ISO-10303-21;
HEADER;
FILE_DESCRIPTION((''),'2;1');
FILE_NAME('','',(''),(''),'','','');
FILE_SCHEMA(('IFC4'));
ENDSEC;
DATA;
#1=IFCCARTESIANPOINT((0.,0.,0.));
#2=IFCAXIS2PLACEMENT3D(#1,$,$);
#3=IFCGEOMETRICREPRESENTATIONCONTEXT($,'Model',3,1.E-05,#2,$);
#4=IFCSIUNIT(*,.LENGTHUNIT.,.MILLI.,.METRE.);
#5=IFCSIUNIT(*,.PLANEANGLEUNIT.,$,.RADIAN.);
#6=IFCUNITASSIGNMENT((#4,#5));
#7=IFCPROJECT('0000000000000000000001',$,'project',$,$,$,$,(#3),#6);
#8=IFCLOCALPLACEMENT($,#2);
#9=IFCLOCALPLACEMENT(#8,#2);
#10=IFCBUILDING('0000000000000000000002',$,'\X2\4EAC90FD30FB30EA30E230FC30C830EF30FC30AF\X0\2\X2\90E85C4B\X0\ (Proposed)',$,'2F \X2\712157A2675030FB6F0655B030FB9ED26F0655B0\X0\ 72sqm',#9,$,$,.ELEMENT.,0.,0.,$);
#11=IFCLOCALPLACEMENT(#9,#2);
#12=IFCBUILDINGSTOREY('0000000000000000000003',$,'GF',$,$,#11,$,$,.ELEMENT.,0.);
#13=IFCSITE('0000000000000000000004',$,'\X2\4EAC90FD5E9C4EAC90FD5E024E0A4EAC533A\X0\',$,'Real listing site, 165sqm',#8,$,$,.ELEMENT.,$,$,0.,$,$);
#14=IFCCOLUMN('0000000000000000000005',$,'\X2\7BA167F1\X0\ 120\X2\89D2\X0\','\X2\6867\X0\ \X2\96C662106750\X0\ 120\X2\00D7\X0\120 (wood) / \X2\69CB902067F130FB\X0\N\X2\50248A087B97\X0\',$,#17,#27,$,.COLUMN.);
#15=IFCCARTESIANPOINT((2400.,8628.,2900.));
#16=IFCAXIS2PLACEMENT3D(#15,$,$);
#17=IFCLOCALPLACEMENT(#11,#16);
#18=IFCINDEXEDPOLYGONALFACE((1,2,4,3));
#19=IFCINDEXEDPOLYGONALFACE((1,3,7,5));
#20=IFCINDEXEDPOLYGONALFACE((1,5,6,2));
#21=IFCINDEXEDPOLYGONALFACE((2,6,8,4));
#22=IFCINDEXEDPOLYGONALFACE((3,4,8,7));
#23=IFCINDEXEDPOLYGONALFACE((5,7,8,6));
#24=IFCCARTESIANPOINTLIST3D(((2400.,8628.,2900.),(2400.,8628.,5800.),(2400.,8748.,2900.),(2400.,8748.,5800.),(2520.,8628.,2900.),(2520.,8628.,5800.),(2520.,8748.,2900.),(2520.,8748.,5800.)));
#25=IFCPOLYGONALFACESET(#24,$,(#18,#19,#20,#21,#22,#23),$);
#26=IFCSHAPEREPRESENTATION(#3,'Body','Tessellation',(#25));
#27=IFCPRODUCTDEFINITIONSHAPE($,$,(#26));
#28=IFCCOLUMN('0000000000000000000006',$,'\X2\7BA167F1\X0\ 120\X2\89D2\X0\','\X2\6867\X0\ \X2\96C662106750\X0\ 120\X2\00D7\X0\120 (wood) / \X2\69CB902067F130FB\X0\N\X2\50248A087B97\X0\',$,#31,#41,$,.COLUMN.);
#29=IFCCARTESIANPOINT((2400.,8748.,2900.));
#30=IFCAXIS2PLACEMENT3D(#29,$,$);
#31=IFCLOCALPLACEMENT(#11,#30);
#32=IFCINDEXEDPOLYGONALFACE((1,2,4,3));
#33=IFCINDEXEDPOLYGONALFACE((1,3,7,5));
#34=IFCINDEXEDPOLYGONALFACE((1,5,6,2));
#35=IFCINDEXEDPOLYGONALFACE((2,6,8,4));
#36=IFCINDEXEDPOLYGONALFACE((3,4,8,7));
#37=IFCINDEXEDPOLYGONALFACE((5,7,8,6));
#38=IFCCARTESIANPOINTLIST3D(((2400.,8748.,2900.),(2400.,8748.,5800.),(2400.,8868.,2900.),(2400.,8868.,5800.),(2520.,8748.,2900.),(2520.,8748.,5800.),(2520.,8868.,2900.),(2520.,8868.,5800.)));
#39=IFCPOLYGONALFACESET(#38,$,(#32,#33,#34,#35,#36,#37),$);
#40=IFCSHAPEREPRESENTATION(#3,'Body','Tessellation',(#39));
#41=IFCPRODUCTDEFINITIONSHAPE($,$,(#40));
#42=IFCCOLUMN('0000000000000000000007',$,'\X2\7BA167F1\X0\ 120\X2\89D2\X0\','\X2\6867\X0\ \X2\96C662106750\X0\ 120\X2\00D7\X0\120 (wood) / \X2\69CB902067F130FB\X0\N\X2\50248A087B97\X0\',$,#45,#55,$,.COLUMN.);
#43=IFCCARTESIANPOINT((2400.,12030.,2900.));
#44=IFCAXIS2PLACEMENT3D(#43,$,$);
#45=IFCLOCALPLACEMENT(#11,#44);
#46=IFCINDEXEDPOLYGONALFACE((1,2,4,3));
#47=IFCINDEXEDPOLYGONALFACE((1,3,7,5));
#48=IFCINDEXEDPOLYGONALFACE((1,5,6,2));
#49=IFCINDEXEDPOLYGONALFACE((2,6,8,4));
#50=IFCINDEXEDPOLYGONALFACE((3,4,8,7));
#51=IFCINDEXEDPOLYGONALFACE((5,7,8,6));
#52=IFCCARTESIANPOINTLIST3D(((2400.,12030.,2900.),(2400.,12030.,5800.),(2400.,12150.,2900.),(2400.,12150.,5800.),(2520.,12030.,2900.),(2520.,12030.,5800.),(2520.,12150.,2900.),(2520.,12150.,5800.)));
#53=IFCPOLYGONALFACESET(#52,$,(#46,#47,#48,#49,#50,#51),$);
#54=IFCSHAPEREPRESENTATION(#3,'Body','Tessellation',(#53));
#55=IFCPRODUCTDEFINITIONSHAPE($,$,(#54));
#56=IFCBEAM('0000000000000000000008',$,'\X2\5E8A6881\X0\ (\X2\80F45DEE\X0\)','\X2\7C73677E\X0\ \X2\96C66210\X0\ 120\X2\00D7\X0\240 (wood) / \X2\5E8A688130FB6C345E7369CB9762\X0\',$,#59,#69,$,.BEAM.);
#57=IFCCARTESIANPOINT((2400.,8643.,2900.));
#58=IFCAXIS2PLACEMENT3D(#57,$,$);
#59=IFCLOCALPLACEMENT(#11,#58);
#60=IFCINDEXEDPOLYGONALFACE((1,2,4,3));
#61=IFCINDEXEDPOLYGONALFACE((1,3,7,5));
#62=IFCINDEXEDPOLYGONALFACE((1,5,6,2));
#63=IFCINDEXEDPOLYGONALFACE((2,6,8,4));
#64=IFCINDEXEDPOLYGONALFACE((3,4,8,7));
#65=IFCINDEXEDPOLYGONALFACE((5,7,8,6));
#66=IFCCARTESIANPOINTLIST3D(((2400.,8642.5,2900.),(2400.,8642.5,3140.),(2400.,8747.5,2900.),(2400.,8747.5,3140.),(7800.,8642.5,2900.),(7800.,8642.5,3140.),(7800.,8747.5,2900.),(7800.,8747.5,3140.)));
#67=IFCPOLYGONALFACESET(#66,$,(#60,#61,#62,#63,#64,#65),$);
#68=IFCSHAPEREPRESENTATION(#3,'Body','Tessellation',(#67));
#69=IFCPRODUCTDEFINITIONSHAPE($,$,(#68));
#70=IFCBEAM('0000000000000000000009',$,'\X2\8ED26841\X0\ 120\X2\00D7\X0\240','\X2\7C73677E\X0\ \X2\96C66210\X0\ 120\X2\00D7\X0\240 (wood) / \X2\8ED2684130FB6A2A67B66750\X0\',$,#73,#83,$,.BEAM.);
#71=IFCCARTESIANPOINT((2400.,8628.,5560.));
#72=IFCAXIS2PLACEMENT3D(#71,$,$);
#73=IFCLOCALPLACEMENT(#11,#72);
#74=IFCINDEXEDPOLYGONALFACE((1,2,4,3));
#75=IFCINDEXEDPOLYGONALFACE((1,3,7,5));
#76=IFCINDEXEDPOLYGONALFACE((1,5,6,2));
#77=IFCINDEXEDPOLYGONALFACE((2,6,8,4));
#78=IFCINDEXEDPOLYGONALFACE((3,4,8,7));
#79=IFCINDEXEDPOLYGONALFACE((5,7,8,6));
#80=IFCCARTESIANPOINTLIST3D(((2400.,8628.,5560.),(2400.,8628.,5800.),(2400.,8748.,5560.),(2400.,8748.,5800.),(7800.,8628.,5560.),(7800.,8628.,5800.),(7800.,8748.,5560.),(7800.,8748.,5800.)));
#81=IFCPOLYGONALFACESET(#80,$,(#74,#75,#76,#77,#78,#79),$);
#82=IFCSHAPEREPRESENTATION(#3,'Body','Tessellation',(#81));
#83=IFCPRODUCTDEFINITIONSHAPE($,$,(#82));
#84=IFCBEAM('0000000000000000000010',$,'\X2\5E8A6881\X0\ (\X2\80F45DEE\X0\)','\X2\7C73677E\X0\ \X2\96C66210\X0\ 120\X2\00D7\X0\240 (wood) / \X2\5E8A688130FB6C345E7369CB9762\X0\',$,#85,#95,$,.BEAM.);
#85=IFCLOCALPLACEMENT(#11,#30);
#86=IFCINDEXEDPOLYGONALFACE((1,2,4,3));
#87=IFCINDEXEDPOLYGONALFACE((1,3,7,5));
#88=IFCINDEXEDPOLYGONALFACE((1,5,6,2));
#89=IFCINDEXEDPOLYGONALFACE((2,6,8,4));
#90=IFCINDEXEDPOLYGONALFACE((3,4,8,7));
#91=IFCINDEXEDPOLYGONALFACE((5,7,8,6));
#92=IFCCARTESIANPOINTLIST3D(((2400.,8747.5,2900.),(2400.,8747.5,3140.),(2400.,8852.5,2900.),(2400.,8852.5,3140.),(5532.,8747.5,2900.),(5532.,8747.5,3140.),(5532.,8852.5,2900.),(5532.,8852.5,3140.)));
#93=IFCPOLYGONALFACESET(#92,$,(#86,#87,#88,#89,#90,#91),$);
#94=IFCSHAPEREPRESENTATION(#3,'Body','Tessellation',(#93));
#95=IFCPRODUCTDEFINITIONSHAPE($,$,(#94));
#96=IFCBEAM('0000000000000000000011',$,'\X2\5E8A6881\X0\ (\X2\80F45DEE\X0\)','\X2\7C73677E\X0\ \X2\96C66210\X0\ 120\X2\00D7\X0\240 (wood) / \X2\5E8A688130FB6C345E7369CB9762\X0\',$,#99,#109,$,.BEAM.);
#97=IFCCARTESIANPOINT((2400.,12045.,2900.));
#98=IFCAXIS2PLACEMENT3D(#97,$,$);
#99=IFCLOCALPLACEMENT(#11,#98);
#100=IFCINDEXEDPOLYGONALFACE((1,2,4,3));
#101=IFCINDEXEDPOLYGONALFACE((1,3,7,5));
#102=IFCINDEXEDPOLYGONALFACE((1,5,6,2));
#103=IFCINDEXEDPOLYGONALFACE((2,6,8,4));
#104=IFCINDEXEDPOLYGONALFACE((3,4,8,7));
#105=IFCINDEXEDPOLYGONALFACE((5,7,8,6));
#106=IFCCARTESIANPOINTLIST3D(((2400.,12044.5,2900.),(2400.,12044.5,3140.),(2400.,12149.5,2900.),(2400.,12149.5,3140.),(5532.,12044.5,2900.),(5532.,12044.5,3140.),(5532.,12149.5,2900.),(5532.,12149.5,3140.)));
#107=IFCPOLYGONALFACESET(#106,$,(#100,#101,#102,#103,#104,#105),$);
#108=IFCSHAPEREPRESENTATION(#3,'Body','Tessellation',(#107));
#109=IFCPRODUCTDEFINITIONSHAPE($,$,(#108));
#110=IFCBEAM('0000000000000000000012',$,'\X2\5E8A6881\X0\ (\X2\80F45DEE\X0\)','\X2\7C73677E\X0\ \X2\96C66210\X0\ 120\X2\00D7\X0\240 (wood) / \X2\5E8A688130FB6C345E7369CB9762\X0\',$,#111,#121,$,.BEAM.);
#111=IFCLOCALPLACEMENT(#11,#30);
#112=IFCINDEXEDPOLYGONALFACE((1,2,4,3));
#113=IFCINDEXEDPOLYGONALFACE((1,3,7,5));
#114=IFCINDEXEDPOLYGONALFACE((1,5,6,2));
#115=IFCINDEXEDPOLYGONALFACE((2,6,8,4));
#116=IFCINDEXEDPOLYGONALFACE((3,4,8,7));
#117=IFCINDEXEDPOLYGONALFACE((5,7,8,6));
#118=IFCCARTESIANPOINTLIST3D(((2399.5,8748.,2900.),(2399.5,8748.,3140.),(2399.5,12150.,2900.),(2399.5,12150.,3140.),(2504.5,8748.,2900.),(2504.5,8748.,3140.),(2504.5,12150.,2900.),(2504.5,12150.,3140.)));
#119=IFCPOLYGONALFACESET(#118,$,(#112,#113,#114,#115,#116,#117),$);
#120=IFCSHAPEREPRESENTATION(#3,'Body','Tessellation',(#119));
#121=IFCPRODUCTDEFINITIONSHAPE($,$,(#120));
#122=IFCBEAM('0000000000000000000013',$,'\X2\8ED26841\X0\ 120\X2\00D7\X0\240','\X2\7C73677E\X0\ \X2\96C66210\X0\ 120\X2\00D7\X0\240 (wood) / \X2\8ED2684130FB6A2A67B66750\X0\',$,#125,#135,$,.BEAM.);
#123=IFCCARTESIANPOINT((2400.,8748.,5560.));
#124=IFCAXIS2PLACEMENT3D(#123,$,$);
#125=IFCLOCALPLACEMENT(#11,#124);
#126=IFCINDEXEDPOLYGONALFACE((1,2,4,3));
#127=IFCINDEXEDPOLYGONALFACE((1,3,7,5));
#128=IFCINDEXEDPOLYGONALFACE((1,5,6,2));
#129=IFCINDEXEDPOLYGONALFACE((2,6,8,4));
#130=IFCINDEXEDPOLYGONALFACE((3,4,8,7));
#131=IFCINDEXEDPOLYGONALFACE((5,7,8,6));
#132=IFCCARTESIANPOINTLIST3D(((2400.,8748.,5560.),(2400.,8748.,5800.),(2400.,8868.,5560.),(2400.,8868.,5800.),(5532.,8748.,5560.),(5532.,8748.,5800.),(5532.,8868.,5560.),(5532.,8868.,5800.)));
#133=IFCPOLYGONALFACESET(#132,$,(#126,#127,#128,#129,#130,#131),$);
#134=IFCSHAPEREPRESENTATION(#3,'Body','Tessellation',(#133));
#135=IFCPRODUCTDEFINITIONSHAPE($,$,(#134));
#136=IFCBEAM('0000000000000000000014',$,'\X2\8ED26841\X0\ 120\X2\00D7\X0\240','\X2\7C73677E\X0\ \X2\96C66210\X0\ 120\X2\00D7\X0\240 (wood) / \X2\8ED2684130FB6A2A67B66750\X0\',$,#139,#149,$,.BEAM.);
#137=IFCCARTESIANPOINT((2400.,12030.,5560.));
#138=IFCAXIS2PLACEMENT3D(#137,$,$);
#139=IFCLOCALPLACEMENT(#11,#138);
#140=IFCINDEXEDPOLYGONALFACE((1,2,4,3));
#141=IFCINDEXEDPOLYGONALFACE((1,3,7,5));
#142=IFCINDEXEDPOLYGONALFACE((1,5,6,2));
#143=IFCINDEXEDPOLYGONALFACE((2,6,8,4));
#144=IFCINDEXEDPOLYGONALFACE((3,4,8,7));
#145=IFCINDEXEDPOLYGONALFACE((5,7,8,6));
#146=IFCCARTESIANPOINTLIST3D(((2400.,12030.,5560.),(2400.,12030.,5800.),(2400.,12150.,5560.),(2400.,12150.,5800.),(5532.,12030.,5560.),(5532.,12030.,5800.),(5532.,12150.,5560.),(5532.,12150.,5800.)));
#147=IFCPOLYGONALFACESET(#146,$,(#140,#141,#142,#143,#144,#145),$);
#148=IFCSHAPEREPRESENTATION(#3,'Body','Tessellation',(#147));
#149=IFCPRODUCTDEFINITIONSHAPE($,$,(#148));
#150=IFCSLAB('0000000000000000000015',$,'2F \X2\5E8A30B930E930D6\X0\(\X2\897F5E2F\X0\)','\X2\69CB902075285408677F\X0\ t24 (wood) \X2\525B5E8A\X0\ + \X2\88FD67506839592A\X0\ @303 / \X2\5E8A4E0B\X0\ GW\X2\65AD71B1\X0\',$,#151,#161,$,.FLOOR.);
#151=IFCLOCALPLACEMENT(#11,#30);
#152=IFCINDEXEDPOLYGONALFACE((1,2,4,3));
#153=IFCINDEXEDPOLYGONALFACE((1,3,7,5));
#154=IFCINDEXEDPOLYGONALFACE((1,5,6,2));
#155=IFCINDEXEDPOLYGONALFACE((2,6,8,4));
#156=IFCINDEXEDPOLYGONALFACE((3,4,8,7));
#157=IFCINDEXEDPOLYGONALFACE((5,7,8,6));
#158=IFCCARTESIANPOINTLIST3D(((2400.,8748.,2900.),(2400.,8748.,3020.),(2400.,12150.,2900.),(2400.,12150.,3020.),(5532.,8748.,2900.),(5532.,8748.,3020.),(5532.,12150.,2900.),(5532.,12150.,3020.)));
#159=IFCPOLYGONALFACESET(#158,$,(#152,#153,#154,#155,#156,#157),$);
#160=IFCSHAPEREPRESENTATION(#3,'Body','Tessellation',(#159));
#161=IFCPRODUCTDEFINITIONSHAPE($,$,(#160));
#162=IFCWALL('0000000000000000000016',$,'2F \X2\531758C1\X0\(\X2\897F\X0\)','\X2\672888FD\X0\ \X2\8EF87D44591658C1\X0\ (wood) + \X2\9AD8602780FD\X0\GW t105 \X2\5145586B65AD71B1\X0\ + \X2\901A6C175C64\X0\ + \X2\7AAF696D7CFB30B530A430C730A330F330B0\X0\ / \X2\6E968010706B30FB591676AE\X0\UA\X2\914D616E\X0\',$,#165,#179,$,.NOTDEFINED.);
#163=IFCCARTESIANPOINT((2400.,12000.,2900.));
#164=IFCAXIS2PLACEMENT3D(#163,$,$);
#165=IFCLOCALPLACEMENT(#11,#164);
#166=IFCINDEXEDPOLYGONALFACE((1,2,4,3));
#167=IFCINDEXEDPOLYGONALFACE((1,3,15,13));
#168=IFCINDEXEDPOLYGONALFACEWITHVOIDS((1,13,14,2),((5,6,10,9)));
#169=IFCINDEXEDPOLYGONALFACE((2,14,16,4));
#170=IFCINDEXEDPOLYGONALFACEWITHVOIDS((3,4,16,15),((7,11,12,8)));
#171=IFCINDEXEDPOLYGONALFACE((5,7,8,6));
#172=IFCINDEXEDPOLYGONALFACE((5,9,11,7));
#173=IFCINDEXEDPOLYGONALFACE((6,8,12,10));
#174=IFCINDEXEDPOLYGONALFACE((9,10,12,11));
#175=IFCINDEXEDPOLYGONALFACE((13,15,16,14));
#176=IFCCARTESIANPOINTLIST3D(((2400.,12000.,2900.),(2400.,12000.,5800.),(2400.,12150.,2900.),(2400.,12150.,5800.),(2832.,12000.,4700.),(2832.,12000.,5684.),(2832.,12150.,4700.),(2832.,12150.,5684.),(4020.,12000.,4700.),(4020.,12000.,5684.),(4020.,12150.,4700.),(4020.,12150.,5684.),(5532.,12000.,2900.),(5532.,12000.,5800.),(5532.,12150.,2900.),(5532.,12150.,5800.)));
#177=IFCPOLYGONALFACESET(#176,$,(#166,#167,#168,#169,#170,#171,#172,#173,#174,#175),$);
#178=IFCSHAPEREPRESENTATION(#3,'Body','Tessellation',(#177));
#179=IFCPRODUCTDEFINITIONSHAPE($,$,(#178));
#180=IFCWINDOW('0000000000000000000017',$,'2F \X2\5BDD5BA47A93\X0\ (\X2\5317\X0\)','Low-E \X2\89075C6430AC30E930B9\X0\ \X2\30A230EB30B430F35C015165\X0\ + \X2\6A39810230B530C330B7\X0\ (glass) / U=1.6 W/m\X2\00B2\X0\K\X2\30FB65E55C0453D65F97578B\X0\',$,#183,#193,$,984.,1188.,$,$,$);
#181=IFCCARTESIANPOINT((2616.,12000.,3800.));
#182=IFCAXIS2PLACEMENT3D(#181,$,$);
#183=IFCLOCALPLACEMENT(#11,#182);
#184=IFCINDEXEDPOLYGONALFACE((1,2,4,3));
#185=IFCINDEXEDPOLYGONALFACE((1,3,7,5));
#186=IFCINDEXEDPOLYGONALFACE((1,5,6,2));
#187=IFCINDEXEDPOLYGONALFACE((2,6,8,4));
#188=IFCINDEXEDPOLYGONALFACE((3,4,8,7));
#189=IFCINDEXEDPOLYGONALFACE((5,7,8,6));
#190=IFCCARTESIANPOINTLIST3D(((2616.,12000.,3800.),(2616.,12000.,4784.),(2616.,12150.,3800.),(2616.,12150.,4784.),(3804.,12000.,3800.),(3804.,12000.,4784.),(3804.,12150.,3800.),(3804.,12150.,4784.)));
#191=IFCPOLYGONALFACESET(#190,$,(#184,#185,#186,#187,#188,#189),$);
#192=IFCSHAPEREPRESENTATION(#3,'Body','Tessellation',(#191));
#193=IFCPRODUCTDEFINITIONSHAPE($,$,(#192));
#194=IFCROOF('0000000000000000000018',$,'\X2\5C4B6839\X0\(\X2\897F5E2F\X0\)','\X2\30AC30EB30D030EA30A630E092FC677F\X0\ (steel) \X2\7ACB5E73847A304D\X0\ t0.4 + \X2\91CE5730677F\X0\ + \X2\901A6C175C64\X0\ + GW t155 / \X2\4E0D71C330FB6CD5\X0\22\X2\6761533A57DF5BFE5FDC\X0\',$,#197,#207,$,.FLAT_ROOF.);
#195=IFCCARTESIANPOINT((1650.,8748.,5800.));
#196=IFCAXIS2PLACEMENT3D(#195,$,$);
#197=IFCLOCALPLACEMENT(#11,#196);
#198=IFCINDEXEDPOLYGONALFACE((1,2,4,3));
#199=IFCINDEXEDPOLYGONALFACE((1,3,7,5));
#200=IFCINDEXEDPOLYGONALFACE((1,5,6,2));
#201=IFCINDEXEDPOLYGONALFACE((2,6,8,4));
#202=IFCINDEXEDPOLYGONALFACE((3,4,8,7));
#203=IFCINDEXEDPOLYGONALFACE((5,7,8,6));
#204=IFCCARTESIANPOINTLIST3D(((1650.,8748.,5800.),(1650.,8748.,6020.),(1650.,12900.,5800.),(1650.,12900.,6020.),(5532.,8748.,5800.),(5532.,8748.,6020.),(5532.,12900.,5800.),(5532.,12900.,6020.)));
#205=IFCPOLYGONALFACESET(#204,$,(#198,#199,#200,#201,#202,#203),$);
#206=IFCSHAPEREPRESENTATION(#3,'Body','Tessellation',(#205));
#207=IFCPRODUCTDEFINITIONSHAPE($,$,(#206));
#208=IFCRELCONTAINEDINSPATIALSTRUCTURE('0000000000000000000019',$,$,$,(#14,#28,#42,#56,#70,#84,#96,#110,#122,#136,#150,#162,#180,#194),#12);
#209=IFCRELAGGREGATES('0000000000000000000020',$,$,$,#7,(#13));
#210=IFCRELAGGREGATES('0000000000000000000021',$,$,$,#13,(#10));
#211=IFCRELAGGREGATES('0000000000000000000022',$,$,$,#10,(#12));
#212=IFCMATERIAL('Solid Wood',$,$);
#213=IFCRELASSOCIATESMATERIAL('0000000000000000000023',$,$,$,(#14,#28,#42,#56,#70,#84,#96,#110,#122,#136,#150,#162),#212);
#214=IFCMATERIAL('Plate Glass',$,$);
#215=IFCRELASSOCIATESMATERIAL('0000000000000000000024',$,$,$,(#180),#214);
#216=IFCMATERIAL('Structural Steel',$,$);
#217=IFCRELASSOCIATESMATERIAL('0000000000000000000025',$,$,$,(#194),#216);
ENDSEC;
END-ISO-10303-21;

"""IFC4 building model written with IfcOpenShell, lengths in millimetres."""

from ifc_helpers import new_model, si_unit, frame, frame_2d, origin, place, context, project, spatial, rectangle, extrude, material, element, fill, save


model = new_model("IFC4")

# Units and contexts
model_context = context("Model", 3, precision=1e-05, world=origin())
ifc_project = project(units=[si_unit("LENGTHUNIT", "METRE", prefix="MILLI"), si_unit("PLANEANGLEUNIT", "RADIAN")], contexts=[model_context])

# Site, building, storey
site_placement = place(None, origin())
site = spatial("IfcSite", under=ifc_project, at=site_placement, Name="京都府京都市上京区", ObjectType="Real listing site, 165sqm", CompositionType="ELEMENT", RefElevation=0.0)
building_placement = place(site_placement, origin())
building = spatial("IfcBuilding", under=site, at=building_placement, Name="京都・リモートワーク2部屋 (Proposed)", ObjectType="2F 無垢材・漆喰・黒漆喰 72sqm", CompositionType="ELEMENT", ElevationOfRefHeight=0.0, ElevationOfTerrain=0.0)
storey_placement = place(building_placement, origin())
storey = spatial("IfcBuildingStorey", under=building, at=storey_placement, Name="GF", CompositionType="ELEMENT", Elevation=0.0)

# Columns
ifc_material_1 = material(Name="Solid Wood")
column_1_placement = place(storey_placement, frame((2400.0, 8628.0, 2900.0)))
element("IfcColumn", 1, at=column_1_placement, inside=storey, material=ifc_material_1, Name="管柱 120角", Description="桧 集成材 120×120 (wood) / 構造柱・N値計算", PredefinedType="COLUMN", context=model_context, shape_type="SweptSolid", body=[
    extrude(rectangle(XDim=120.0, YDim=120.0, at=frame_2d((60.0, 60.0))), frame((2400.0, 8628.0, 2900.0)), (0.0, 0.0, 1.0), 2900.0),
])
column_2_placement = place(storey_placement, frame((2400.0, 8748.0, 2900.0)))
element("IfcColumn", 2, at=column_2_placement, inside=storey, material=ifc_material_1, Name="管柱 120角", Description="桧 集成材 120×120 (wood) / 構造柱・N値計算", PredefinedType="COLUMN", context=model_context, shape_type="SweptSolid", body=[
    extrude(rectangle(XDim=120.0, YDim=120.0, at=frame_2d((60.0, 60.0))), frame((2400.0, 8748.0, 2900.0)), (0.0, 0.0, 1.0), 2900.0),
])
column_3_placement = place(storey_placement, frame((2400.0, 12030.0, 2900.0)))
element("IfcColumn", 3, at=column_3_placement, inside=storey, material=ifc_material_1, Name="管柱 120角", Description="桧 集成材 120×120 (wood) / 構造柱・N値計算", PredefinedType="COLUMN", context=model_context, shape_type="SweptSolid", body=[
    extrude(rectangle(XDim=120.0, YDim=120.0, at=frame_2d((60.0, 60.0))), frame((2400.0, 12030.0, 2900.0)), (0.0, 0.0, 1.0), 2900.0),
])

# Beams
beam_1_placement = place(storey_placement, frame((2400.0, 8643.0, 2900.0)))
element("IfcBeam", 4, at=beam_1_placement, inside=storey, material=ifc_material_1, Name="床梁 (胴差)", Description="米松 集成 120×240 (wood) / 床梁・水平構面", PredefinedType="BEAM", context=model_context, shape_type="SweptSolid", body=[
    extrude(rectangle(XDim=5400.0, YDim=105.0, at=frame_2d((2700.0, 52.0))), frame((2400.0, 8643.0, 2900.0)), (0.0, 0.0, 1.0), 240.0),
])
beam_2_placement = place(storey_placement, frame((2400.0, 8628.0, 5560.0)))
element("IfcBeam", 5, at=beam_2_placement, inside=storey, material=ifc_material_1, Name="軒桁 120×240", Description="米松 集成 120×240 (wood) / 軒桁・横架材", PredefinedType="BEAM", context=model_context, shape_type="SweptSolid", body=[
    extrude(rectangle(XDim=5400.0, YDim=120.0, at=frame_2d((2700.0, 60.0))), frame((2400.0, 8628.0, 5560.0)), (0.0, 0.0, 1.0), 240.0),
])
beam_3_placement = place(storey_placement, frame((2400.0, 8748.0, 2900.0)))
element("IfcBeam", 6, at=beam_3_placement, inside=storey, material=ifc_material_1, Name="床梁 (胴差)", Description="米松 集成 120×240 (wood) / 床梁・水平構面", PredefinedType="BEAM", context=model_context, shape_type="SweptSolid", body=[
    extrude(rectangle(XDim=3132.0, YDim=105.0, at=frame_2d((1566.0, 52.0))), frame((2400.0, 8748.0, 2900.0)), (0.0, 0.0, 1.0), 240.0),
])
beam_4_placement = place(storey_placement, frame((2400.0, 12045.0, 2900.0)))
element("IfcBeam", 7, at=beam_4_placement, inside=storey, material=ifc_material_1, Name="床梁 (胴差)", Description="米松 集成 120×240 (wood) / 床梁・水平構面", PredefinedType="BEAM", context=model_context, shape_type="SweptSolid", body=[
    extrude(rectangle(XDim=3132.0, YDim=105.0, at=frame_2d((1566.0, 52.0))), frame((2400.0, 12045.0, 2900.0)), (0.0, 0.0, 1.0), 240.0),
])
beam_5_placement = place(storey_placement, frame((2400.0, 8748.0, 2900.0)))
element("IfcBeam", 8, at=beam_5_placement, inside=storey, material=ifc_material_1, Name="床梁 (胴差)", Description="米松 集成 120×240 (wood) / 床梁・水平構面", PredefinedType="BEAM", context=model_context, shape_type="SweptSolid", body=[
    extrude(rectangle(XDim=105.0, YDim=3402.0, at=frame_2d((52.0, 1701.0))), frame((2400.0, 8748.0, 2900.0)), (0.0, 0.0, 1.0), 240.0),
])
beam_6_placement = place(storey_placement, frame((2400.0, 8748.0, 5560.0)))
element("IfcBeam", 9, at=beam_6_placement, inside=storey, material=ifc_material_1, Name="軒桁 120×240", Description="米松 集成 120×240 (wood) / 軒桁・横架材", PredefinedType="BEAM", context=model_context, shape_type="SweptSolid", body=[
    extrude(rectangle(XDim=3132.0, YDim=120.0, at=frame_2d((1566.0, 60.0))), frame((2400.0, 8748.0, 5560.0)), (0.0, 0.0, 1.0), 240.0),
])
beam_7_placement = place(storey_placement, frame((2400.0, 12030.0, 5560.0)))
element("IfcBeam", 10, at=beam_7_placement, inside=storey, material=ifc_material_1, Name="軒桁 120×240", Description="米松 集成 120×240 (wood) / 軒桁・横架材", PredefinedType="BEAM", context=model_context, shape_type="SweptSolid", body=[
    extrude(rectangle(XDim=3132.0, YDim=120.0, at=frame_2d((1566.0, 60.0))), frame((2400.0, 12030.0, 5560.0)), (0.0, 0.0, 1.0), 240.0),
])

# Slab
slab_placement = place(storey_placement, frame((2400.0, 8748.0, 2900.0)))
element("IfcSlab", 11, at=slab_placement, inside=storey, material=ifc_material_1, Name="2F 床スラブ(西帯)", Description="構造用合板 t24 (wood) 剛床 + 製材根太 @303 / 床下 GW断熱", PredefinedType="FLOOR", context=model_context, shape_type="SweptSolid", body=[
    extrude(rectangle(XDim=3132.0, YDim=3402.0, at=frame_2d((1566.0, 1701.0))), frame((2400.0, 8748.0, 2900.0)), (0.0, 0.0, 1.0), 120.0),
])

# Wall, opening, window
wall_1_placement = place(storey_placement, frame((2400.0, 12000.0, 2900.0)))
wall_1 = element("IfcWall", 12, at=wall_1_placement, inside=storey, material=ifc_material_1, Name="2F 北壁(西)", Description="木製 軸組外壁 (wood) + 高性能GW t105 充填断熱 + 通気層 + 窯業系サイディング / 準耐火・外皮UA配慮", PredefinedType="NOTDEFINED", context=model_context, shape_type="SweptSolid", body=[
    extrude(rectangle(XDim=3132.0, YDim=150.0, at=frame_2d((1566.0, 75.0))), frame((2400.0, 12000.0, 2900.0)), (0.0, 0.0, 1.0), 2900.0),
])
opening_placement = place(storey_placement, frame((2616.0, 12000.0, 3800.0)))
opening = element("IfcOpeningElement", 13, at=opening_placement, cuts=wall_1, PredefinedType="NOTDEFINED", context=model_context, shape_type="SweptSolid", body=[
    extrude(rectangle(XDim=1188.0, YDim=150.0, at=frame_2d((594.0, 75.0))), frame((2616.0, 12000.0, 3800.0)), (0.0, 0.0, 1.0), 984.0),
])
ifc_material_2 = material(Name="Plate Glass")
window_placement = place(storey_placement, frame((2616.0, 12000.0, 3800.0)))
window = element("IfcWindow", 14, at=window_placement, inside=storey, material=ifc_material_2, Name="2F 寝室窓 (北)", Description="Low-E 複層ガラス アルゴン封入 + 樹脂サッシ (glass) / U=1.6 W/m²K・日射取得型", OverallHeight=984.0, OverallWidth=1188.0, context=model_context, shape_type="SweptSolid", body=[
    extrude(rectangle(XDim=1188.0, YDim=150.0, at=frame_2d((594.0, 75.0))), frame((2616.0, 12000.0, 3800.0)), (0.0, 0.0, 1.0), 984.0),
])
fill(opening, window)

# Roof
ifc_material_3 = material(Name="Structural Steel")
for number, where, name in (
    (15, (1650.0, 8748.0, 5800.0), "屋根(西帯)"),
):
    element("IfcRoof", number, at=place(storey_placement, frame(where)), inside=storey, material=ifc_material_3, Name=name, Description="ガルバリウム鋼板 (steel) 立平葺き t0.4 + 野地板 + 通気層 + GW t155 / 不燃・法22条区域対応", PredefinedType="FLAT_ROOF", context=model_context, shape_type="SweptSolid", body=[
        extrude(rectangle(XDim=3882.0, YDim=4152.0, at=frame_2d((1941.0, 2076.0))), frame((1650.0, 8748.0, 5800.0)), (0.0, 0.0, 1.0), 220.0),
    ])

save(model, "model.ifc")
